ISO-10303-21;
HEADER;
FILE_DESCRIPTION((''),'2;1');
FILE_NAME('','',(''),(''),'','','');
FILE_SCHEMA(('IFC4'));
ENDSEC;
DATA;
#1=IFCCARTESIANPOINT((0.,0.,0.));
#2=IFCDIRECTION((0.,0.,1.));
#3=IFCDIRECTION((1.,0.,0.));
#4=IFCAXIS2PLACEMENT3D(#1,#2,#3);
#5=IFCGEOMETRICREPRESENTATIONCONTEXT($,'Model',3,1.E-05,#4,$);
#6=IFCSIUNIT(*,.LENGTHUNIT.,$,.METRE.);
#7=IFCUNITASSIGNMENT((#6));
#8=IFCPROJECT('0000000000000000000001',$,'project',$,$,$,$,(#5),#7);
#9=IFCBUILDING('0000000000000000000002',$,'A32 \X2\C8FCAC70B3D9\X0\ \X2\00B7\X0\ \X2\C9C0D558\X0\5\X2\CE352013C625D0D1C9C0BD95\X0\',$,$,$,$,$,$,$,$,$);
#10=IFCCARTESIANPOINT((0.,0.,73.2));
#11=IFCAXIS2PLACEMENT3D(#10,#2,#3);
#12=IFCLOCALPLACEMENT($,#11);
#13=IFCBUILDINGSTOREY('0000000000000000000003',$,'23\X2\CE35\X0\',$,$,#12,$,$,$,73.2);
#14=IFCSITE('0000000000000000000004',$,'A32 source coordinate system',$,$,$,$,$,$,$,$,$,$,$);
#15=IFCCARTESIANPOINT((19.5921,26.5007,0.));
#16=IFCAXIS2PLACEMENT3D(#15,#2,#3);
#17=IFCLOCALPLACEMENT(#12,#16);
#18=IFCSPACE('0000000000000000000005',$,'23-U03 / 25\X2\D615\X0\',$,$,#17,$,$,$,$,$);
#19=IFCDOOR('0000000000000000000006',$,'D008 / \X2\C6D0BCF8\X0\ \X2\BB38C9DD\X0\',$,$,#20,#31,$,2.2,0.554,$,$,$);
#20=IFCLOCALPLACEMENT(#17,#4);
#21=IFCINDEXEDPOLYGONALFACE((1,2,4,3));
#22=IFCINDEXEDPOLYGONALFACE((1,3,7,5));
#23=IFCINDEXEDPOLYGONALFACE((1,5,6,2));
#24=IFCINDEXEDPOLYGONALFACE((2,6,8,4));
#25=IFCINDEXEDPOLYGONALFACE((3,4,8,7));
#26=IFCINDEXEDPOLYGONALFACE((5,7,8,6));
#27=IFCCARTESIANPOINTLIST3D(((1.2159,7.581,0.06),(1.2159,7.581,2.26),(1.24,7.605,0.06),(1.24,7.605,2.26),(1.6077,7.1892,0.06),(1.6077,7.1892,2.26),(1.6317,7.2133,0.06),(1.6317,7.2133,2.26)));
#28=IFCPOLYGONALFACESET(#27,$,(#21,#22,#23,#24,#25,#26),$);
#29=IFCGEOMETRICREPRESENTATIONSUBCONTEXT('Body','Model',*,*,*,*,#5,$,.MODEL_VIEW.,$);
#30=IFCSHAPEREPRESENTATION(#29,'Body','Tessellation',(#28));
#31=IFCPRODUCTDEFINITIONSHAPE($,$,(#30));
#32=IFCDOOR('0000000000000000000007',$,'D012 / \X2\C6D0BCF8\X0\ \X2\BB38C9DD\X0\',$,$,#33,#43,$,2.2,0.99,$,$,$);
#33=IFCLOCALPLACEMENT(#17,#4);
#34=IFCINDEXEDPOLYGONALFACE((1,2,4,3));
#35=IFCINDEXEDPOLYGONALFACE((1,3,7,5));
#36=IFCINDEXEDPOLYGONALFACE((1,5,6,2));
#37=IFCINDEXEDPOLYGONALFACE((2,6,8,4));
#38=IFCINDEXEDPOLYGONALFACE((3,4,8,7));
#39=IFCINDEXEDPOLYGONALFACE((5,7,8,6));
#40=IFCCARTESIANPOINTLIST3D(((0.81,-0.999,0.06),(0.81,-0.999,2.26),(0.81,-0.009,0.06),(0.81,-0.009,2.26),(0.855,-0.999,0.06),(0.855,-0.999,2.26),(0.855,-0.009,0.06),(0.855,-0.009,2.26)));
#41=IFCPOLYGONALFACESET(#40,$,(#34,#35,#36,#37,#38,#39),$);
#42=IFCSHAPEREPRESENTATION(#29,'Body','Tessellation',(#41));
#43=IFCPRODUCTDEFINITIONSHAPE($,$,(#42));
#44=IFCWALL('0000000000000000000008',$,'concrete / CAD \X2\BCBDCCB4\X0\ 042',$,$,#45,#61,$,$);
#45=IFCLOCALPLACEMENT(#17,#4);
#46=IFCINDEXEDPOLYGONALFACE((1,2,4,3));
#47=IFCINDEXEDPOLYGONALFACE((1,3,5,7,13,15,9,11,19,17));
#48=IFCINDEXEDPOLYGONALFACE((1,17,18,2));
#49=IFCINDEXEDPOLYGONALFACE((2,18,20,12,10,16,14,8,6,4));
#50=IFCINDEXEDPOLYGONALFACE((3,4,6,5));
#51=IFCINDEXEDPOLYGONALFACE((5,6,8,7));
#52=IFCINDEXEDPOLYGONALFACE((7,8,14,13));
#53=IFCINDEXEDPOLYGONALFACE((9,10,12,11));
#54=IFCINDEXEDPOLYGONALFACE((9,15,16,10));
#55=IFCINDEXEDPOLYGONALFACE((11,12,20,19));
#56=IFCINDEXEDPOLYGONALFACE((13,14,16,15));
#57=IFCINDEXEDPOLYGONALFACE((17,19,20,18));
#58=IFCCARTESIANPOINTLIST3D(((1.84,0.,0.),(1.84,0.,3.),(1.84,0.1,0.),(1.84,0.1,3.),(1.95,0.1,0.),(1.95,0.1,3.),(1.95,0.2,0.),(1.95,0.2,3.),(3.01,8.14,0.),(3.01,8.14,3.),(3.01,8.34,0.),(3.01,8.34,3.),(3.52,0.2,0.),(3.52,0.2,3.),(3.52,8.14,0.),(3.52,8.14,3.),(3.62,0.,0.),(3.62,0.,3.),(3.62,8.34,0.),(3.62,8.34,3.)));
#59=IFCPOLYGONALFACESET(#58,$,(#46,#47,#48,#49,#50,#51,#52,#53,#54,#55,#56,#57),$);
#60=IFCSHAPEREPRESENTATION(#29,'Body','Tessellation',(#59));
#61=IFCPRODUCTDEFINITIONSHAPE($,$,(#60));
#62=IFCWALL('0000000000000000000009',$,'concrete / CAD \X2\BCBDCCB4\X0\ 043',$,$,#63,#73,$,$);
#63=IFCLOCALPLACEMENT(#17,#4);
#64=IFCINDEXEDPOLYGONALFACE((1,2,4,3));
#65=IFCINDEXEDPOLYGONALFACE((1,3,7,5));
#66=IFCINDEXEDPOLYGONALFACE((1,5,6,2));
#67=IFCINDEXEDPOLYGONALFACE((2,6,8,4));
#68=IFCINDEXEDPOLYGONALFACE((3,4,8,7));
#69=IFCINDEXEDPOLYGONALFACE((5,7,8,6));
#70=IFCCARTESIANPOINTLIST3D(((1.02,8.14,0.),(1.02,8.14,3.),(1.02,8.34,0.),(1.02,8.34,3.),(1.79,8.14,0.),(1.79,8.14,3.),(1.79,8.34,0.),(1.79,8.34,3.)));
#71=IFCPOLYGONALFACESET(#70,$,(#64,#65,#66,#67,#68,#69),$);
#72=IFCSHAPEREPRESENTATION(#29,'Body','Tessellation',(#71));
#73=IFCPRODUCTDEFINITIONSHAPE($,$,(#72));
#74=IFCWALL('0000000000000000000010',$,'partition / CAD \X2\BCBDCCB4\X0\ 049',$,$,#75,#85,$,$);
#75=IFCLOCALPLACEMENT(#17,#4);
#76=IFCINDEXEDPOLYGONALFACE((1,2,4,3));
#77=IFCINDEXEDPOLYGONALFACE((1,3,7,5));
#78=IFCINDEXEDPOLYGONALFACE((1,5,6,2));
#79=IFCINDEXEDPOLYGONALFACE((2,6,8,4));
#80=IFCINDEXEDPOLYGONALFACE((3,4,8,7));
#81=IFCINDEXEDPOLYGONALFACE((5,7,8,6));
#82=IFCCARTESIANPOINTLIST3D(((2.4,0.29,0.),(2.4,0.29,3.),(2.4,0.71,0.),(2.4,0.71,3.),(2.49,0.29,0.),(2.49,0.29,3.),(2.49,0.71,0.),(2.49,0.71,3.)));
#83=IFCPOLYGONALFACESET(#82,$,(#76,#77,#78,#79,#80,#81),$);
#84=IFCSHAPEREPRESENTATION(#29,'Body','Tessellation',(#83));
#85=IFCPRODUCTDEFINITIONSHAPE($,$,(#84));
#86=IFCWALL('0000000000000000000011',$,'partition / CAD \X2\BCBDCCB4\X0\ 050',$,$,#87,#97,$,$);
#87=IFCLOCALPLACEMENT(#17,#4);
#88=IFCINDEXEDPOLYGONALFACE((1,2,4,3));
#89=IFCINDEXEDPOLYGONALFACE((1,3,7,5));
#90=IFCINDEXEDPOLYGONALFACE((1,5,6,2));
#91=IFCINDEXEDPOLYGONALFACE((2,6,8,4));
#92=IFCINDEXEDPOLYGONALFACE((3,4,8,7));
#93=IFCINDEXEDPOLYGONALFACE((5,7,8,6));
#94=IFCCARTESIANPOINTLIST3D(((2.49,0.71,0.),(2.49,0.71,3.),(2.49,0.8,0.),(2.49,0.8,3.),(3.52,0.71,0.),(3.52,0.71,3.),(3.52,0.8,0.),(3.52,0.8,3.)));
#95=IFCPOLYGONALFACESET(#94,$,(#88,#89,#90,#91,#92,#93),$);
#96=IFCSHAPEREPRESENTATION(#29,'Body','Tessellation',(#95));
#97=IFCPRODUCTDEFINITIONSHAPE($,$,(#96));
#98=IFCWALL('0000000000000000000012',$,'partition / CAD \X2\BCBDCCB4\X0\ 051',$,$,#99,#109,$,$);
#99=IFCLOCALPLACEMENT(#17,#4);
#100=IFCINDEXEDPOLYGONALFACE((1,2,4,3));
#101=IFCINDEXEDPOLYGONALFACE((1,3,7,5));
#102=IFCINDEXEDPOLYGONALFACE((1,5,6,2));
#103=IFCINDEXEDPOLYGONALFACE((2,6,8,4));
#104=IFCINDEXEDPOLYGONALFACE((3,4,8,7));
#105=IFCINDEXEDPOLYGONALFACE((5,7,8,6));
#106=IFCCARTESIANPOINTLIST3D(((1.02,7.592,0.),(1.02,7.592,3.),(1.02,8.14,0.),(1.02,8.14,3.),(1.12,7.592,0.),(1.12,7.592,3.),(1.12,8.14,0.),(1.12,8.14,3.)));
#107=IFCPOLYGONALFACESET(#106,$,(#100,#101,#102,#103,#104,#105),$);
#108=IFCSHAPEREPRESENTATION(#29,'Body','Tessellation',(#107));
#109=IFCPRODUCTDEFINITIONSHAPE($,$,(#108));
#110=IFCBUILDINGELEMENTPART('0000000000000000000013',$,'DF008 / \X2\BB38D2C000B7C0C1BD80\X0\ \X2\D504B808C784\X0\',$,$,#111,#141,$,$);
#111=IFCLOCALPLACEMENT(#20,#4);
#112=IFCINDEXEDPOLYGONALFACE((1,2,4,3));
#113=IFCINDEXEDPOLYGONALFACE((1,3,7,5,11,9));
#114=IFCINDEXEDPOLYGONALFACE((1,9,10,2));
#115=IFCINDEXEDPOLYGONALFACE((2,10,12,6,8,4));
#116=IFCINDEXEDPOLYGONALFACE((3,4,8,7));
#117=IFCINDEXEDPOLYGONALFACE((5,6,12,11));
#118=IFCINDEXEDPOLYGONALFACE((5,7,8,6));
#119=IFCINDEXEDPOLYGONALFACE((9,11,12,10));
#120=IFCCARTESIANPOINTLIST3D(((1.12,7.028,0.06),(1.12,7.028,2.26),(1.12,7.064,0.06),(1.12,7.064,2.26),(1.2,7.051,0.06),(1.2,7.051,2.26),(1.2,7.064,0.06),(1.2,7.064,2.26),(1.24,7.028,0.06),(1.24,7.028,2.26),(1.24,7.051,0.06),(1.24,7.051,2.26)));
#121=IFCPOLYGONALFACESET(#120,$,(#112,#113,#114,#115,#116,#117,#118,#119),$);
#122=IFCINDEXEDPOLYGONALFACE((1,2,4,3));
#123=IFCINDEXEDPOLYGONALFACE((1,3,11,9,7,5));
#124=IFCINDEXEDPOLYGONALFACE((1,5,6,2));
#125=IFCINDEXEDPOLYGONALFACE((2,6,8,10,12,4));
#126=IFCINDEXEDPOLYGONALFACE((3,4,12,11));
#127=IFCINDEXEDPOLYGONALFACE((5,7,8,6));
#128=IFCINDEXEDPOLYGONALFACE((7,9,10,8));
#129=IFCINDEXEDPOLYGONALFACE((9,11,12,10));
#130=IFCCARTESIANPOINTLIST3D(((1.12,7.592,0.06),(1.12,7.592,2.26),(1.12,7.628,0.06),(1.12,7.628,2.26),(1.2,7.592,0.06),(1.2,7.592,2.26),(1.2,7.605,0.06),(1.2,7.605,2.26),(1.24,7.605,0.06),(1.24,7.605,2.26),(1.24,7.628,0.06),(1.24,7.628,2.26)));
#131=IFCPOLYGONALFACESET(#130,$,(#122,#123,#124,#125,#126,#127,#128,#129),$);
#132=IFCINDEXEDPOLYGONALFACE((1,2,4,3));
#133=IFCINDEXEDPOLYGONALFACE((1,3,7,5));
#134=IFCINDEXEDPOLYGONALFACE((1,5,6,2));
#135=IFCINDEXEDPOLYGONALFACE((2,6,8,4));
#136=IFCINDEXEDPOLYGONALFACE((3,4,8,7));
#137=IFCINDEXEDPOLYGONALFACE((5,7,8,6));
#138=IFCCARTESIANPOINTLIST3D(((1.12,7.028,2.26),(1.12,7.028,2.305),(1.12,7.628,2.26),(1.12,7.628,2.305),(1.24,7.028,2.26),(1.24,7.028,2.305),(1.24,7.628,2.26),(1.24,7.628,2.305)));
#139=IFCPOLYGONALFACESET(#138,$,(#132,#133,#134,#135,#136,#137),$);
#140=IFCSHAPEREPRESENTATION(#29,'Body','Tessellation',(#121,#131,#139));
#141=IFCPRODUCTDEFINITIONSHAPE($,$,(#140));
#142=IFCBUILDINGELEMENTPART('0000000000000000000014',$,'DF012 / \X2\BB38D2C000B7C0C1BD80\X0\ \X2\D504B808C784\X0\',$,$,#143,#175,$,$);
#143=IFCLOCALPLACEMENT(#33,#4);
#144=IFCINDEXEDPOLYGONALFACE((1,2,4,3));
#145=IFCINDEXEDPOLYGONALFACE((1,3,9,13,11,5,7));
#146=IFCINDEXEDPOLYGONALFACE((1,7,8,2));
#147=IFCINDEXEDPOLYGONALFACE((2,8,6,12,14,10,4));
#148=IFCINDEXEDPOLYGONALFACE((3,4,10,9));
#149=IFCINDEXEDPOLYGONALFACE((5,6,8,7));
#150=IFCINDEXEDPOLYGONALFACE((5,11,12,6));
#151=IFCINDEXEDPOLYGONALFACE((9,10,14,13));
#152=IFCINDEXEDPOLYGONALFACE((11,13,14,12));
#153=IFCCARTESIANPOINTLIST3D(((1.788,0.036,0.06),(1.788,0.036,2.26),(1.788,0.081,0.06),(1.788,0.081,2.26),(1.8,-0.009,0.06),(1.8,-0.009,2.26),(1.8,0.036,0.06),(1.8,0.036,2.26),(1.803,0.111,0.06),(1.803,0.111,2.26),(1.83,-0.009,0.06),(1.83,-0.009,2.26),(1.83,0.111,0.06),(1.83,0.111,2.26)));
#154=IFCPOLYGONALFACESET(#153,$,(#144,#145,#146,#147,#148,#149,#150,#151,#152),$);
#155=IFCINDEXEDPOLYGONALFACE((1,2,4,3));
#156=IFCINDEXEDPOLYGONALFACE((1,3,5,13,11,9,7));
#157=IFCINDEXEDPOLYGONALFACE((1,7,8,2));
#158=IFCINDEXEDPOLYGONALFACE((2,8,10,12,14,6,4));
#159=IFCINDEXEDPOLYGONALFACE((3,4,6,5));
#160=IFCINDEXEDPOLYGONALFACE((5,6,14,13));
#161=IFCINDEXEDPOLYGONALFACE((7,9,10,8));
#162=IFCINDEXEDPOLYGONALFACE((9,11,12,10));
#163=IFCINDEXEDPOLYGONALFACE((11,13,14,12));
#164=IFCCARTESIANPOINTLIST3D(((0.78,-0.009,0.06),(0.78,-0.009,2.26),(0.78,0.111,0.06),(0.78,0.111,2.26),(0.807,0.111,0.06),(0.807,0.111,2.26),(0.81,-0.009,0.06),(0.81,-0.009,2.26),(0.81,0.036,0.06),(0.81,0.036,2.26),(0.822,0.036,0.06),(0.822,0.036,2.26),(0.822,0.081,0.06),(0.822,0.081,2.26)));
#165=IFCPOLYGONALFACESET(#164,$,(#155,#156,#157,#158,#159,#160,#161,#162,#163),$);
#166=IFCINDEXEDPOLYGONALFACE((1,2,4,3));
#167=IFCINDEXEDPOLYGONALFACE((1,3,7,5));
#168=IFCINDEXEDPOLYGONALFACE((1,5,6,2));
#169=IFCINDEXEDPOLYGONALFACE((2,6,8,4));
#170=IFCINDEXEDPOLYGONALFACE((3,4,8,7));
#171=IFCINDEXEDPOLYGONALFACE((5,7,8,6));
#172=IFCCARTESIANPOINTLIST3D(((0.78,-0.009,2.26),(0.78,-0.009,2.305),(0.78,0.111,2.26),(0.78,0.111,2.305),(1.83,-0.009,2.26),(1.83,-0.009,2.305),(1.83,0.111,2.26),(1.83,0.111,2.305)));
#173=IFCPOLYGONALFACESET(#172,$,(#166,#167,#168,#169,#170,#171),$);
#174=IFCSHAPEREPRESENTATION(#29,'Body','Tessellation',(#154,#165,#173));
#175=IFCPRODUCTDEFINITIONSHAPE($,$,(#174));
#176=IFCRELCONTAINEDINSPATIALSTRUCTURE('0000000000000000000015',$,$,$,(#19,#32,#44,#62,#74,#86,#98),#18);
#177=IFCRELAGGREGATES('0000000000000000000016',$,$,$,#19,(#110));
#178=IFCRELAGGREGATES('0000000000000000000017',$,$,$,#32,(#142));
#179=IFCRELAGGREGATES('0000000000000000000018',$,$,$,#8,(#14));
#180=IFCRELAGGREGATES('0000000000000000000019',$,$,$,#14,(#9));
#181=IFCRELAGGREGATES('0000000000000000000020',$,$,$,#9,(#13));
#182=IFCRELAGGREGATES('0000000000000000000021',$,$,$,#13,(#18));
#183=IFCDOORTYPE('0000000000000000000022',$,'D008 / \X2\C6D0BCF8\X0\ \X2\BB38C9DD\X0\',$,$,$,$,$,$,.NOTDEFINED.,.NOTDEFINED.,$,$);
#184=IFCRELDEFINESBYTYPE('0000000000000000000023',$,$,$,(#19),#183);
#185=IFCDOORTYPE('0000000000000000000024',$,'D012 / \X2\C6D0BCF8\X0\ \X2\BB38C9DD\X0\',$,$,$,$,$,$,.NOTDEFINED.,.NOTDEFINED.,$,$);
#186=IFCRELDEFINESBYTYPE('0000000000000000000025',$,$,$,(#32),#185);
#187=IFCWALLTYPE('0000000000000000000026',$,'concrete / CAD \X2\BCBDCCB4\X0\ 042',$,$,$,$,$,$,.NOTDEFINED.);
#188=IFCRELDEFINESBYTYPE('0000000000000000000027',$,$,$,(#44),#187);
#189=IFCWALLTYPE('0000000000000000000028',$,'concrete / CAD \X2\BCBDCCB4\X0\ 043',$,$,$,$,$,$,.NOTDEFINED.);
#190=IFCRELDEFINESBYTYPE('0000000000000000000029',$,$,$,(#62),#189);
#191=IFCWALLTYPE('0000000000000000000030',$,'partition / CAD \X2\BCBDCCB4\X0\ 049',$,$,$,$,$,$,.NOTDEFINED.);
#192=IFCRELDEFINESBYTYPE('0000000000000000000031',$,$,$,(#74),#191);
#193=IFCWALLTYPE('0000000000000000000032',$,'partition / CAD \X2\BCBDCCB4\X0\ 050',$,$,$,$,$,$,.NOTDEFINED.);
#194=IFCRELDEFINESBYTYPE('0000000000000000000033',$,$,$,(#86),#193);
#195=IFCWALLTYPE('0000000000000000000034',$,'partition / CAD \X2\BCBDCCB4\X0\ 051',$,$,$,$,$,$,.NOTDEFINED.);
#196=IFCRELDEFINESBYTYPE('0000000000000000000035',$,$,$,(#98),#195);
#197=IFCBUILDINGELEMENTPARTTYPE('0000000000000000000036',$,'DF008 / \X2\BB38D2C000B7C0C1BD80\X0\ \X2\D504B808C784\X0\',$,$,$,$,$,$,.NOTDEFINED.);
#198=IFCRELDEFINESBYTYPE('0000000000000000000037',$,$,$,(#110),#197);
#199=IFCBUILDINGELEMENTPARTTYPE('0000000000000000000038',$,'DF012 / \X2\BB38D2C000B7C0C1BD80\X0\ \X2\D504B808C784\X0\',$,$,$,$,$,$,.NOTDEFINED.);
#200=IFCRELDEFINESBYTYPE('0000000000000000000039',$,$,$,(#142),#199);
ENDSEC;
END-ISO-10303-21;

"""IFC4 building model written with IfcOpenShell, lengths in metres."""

from ifc_helpers import new_model, si_unit, frame, origin, origin_with_axes, place, context, subcontext, project, spatial, polyline, outline, extrude, source, transform, mapped, type_object, type_shapes, element, aggregate, save


model = new_model("IFC4")

# Units and contexts
model_context = context("Model", 3, precision=1e-05, world=origin_with_axes())
body_context = subcontext(model_context, "Body", "Model", "MODEL_VIEW")
ifc_project = project(units=[si_unit("LENGTHUNIT", "METRE")], contexts=[model_context])

# Site, building, storey, space
storey_placement = place(None, frame((0.0, 0.0, 73.2), z_axis=(0.0, 0.0, 1.0), x_axis=(1.0, 0.0, 0.0)))
space_placement = place(storey_placement, frame((19.5921, 26.5007, 0.0), z_axis=(0.0, 0.0, 1.0), x_axis=(1.0, 0.0, 0.0)))
site = spatial("IfcSite", under=ifc_project, Name="A32 source coordinate system")
building = spatial("IfcBuilding", under=site, Name="A32 주거동 · 지하5층–옥탑지붕")
storey = spatial("IfcBuildingStorey", under=building, at=storey_placement, Name="23층", Elevation=73.2)
space = spatial("IfcSpace", under=storey, at=space_placement, Name="23-U03 / 25형")

# Doors
door_type_1 = type_object("IfcDoorType", Name="D008 / 원본 문짝", OperationType="NOTDEFINED", PredefinedType="NOTDEFINED")
shared_shape_1 = source(origin(), body_context, "Body", "SweptSolid", [
    extrude(outline(polyline([(1.24, 7.605), (1.6317, 7.2133), (1.6077, 7.1892), (1.2159, 7.581), (1.24, 7.605)])), frame((0.0, 0.0, 0.06)), (0.0, 0.0, 1.0), 2.2),
])
type_shapes(door_type_1, [shared_shape_1])
door_1_placement = place(space_placement, origin_with_axes())
door_1 = element("IfcDoor", 1, at=door_1_placement, inside=space, type_object=door_type_1, Name="D008 / 원본 문짝", OverallHeight=2.2, OverallWidth=0.554, context=body_context, shape_type="MappedRepresentation", body=[
    mapped(shared_shape_1, transform((0.0, 0.0, 0.0), scale=1.0)),
])
door_type_2 = type_object("IfcDoorType", Name="D012 / 원본 문짝", OperationType="NOTDEFINED", PredefinedType="NOTDEFINED")
shared_shape_2 = source(origin(), body_context, "Body", "SweptSolid", [
    extrude(outline(polyline([(0.855, -0.999), (0.81, -0.999), (0.81, -0.009), (0.855, -0.009), (0.855, -0.999)])), frame((0.0, 0.0, 0.06)), (0.0, 0.0, 1.0), 2.2),
])
type_shapes(door_type_2, [shared_shape_2])
door_2_placement = place(space_placement, origin_with_axes())
door_2 = element("IfcDoor", 2, at=door_2_placement, inside=space, type_object=door_type_2, Name="D012 / 원본 문짝", OverallHeight=2.2, OverallWidth=0.99, context=body_context, shape_type="MappedRepresentation", body=[
    mapped(shared_shape_2, transform((0.0, 0.0, 0.0), scale=1.0)),
])

# Walls
wall_type_1 = type_object("IfcWallType", Name="concrete / CAD 벽체 042", PredefinedType="NOTDEFINED")
shared_shape_3 = source(origin(), body_context, "Body", "SweptSolid", [
    extrude(outline(polyline([(3.01, 8.34), (3.97, 8.34), (3.97, 8.34), (3.62, 8.34), (3.62, 0.0), (1.84, 0.0), (1.84, 0.1), (1.95, 0.1), (1.95, 0.2), (3.52, 0.2), (3.52, 8.14), (3.01, 8.14), (3.01, 8.34)])), origin(), (0.0, 0.0, 1.0), 3.0),
])
type_shapes(wall_type_1, [shared_shape_3])
wall_1_placement = place(space_placement, origin_with_axes())
element("IfcWall", 3, at=wall_1_placement, inside=space, type_object=wall_type_1, Name="concrete / CAD 벽체 042", context=body_context, shape_type="MappedRepresentation", body=[
    mapped(shared_shape_3, transform((0.0, 0.0, 0.0), scale=1.0)),
])
wall_type_2 = type_object("IfcWallType", Name="concrete / CAD 벽체 043", PredefinedType="NOTDEFINED")
shared_shape_4 = source(origin(), body_context, "Body", "SweptSolid", [
    extrude(outline(polyline([(1.79, 8.14), (1.02, 8.14), (1.02, 8.34), (1.79, 8.34), (1.79, 8.14)])), origin(), (0.0, 0.0, 1.0), 3.0),
])
type_shapes(wall_type_2, [shared_shape_4])
wall_2_placement = place(space_placement, origin_with_axes())
element("IfcWall", 4, at=wall_2_placement, inside=space, type_object=wall_type_2, Name="concrete / CAD 벽체 043", context=body_context, shape_type="MappedRepresentation", body=[
    mapped(shared_shape_4, transform((0.0, 0.0, 0.0), scale=1.0)),
])
wall_type_3 = type_object("IfcWallType", Name="partition / CAD 벽체 049", PredefinedType="NOTDEFINED")
shared_shape_5 = source(origin(), body_context, "Body", "SweptSolid", [
    extrude(outline(polyline([(2.49, 0.29), (2.4, 0.29), (2.4, 0.71), (2.49, 0.71), (2.49, 0.29)])), origin(), (0.0, 0.0, 1.0), 3.0),
])
type_shapes(wall_type_3, [shared_shape_5])
wall_3_placement = place(space_placement, origin_with_axes())
element("IfcWall", 5, at=wall_3_placement, inside=space, type_object=wall_type_3, Name="partition / CAD 벽체 049", context=body_context, shape_type="MappedRepresentation", body=[
    mapped(shared_shape_5, transform((0.0, 0.0, 0.0), scale=1.0)),
])
wall_type_4 = type_object("IfcWallType", Name="partition / CAD 벽체 050", PredefinedType="NOTDEFINED")
shared_shape_6 = source(origin(), body_context, "Body", "SweptSolid", [
    extrude(outline(polyline([(2.49, 0.71), (2.49, 0.8), (3.52, 0.8), (3.52, 0.71), (2.49, 0.71)])), origin(), (0.0, 0.0, 1.0), 3.0),
])
type_shapes(wall_type_4, [shared_shape_6])
wall_4_placement = place(space_placement, origin_with_axes())
element("IfcWall", 6, at=wall_4_placement, inside=space, type_object=wall_type_4, Name="partition / CAD 벽체 050", context=body_context, shape_type="MappedRepresentation", body=[
    mapped(shared_shape_6, transform((0.0, 0.0, 0.0), scale=1.0)),
])
wall_type_5 = type_object("IfcWallType", Name="partition / CAD 벽체 051", PredefinedType="NOTDEFINED")
shared_shape_7 = source(origin(), body_context, "Body", "SweptSolid", [
    extrude(outline(polyline([(1.02, 8.14), (1.12, 8.14), (1.12, 7.592), (1.02, 7.592), (1.02, 8.14)])), origin(), (0.0, 0.0, 1.0), 3.0),
])
type_shapes(wall_type_5, [shared_shape_7])
wall_5_placement = place(space_placement, origin_with_axes())
element("IfcWall", 7, at=wall_5_placement, inside=space, type_object=wall_type_5, Name="partition / CAD 벽체 051", context=body_context, shape_type="MappedRepresentation", body=[
    mapped(shared_shape_7, transform((0.0, 0.0, 0.0), scale=1.0)),
])

# Building element parts
building_element_part_type_1 = type_object("IfcBuildingElementPartType", Name="DF008 / 문틀·상부 프레임", PredefinedType="NOTDEFINED")
shared_shape_8 = source(origin(), body_context, "Body", "SweptSolid", [
    extrude(outline(polyline([(1.12, 7.064), (1.2, 7.064), (1.2, 7.051), (1.24, 7.051), (1.24, 7.028), (1.12, 7.028), (1.12, 7.064)])), frame((0.0, 0.0, 0.06)), (0.0, 0.0, 1.0), 2.2),
    extrude(outline(polyline([(1.24, 7.628), (1.24, 7.605), (1.2, 7.605), (1.2, 7.592), (1.12, 7.592), (1.12, 7.628), (1.24, 7.628)])), frame((0.0, 0.0, 0.06)), (0.0, 0.0, 1.0), 2.2),
    extrude(outline(polyline([(1.12, 7.028), (1.12, 7.628), (1.24, 7.628), (1.24, 7.028), (1.12, 7.028)])), frame((0.0, 0.0, 2.26)), (0.0, 0.0, 1.0), 0.045),
])
type_shapes(building_element_part_type_1, [shared_shape_8])
building_element_part_1_placement = place(door_1_placement, origin_with_axes())
building_element_part_1 = element("IfcBuildingElementPart", 8, at=building_element_part_1_placement, type_object=building_element_part_type_1, Name="DF008 / 문틀·상부 프레임", context=body_context, shape_type="MappedRepresentation", body=[
    mapped(shared_shape_8, transform((0.0, 0.0, 0.0), scale=1.0)),
])
aggregate(door_1, [building_element_part_1])
building_element_part_type_2 = type_object("IfcBuildingElementPartType", Name="DF012 / 문틀·상부 프레임", PredefinedType="NOTDEFINED")
shared_shape_9 = source(origin(), body_context, "Body", "SweptSolid", [
    extrude(outline(polyline([(1.8, -0.009), (1.8, 0.036), (1.788, 0.036), (1.788, 0.081), (1.803, 0.111), (1.83, 0.111), (1.83, -0.009), (1.8, -0.009)])), frame((0.0, 0.0, 0.06)), (0.0, 0.0, 1.0), 2.2),
    extrude(outline(polyline([(0.78, 0.111), (0.807, 0.111), (0.822, 0.081), (0.822, 0.036), (0.81, 0.036), (0.81, -0.009), (0.78, -0.009), (0.78, 0.111)])), frame((0.0, 0.0, 0.06)), (0.0, 0.0, 1.0), 2.2),
    extrude(outline(polyline([(0.78, -0.009), (0.78, 0.111), (1.83, 0.111), (1.83, -0.009), (0.78, -0.009)])), frame((0.0, 0.0, 2.26)), (0.0, 0.0, 1.0), 0.045),
])
type_shapes(building_element_part_type_2, [shared_shape_9])
building_element_part_2_placement = place(door_2_placement, origin_with_axes())
building_element_part_2 = element("IfcBuildingElementPart", 9, at=building_element_part_2_placement, type_object=building_element_part_type_2, Name="DF012 / 문틀·상부 프레임", context=body_context, shape_type="MappedRepresentation", body=[
    mapped(shared_shape_9, transform((0.0, 0.0, 0.0), scale=1.0)),
])
aggregate(door_2, [building_element_part_2])

save(model, "model.ifc")
